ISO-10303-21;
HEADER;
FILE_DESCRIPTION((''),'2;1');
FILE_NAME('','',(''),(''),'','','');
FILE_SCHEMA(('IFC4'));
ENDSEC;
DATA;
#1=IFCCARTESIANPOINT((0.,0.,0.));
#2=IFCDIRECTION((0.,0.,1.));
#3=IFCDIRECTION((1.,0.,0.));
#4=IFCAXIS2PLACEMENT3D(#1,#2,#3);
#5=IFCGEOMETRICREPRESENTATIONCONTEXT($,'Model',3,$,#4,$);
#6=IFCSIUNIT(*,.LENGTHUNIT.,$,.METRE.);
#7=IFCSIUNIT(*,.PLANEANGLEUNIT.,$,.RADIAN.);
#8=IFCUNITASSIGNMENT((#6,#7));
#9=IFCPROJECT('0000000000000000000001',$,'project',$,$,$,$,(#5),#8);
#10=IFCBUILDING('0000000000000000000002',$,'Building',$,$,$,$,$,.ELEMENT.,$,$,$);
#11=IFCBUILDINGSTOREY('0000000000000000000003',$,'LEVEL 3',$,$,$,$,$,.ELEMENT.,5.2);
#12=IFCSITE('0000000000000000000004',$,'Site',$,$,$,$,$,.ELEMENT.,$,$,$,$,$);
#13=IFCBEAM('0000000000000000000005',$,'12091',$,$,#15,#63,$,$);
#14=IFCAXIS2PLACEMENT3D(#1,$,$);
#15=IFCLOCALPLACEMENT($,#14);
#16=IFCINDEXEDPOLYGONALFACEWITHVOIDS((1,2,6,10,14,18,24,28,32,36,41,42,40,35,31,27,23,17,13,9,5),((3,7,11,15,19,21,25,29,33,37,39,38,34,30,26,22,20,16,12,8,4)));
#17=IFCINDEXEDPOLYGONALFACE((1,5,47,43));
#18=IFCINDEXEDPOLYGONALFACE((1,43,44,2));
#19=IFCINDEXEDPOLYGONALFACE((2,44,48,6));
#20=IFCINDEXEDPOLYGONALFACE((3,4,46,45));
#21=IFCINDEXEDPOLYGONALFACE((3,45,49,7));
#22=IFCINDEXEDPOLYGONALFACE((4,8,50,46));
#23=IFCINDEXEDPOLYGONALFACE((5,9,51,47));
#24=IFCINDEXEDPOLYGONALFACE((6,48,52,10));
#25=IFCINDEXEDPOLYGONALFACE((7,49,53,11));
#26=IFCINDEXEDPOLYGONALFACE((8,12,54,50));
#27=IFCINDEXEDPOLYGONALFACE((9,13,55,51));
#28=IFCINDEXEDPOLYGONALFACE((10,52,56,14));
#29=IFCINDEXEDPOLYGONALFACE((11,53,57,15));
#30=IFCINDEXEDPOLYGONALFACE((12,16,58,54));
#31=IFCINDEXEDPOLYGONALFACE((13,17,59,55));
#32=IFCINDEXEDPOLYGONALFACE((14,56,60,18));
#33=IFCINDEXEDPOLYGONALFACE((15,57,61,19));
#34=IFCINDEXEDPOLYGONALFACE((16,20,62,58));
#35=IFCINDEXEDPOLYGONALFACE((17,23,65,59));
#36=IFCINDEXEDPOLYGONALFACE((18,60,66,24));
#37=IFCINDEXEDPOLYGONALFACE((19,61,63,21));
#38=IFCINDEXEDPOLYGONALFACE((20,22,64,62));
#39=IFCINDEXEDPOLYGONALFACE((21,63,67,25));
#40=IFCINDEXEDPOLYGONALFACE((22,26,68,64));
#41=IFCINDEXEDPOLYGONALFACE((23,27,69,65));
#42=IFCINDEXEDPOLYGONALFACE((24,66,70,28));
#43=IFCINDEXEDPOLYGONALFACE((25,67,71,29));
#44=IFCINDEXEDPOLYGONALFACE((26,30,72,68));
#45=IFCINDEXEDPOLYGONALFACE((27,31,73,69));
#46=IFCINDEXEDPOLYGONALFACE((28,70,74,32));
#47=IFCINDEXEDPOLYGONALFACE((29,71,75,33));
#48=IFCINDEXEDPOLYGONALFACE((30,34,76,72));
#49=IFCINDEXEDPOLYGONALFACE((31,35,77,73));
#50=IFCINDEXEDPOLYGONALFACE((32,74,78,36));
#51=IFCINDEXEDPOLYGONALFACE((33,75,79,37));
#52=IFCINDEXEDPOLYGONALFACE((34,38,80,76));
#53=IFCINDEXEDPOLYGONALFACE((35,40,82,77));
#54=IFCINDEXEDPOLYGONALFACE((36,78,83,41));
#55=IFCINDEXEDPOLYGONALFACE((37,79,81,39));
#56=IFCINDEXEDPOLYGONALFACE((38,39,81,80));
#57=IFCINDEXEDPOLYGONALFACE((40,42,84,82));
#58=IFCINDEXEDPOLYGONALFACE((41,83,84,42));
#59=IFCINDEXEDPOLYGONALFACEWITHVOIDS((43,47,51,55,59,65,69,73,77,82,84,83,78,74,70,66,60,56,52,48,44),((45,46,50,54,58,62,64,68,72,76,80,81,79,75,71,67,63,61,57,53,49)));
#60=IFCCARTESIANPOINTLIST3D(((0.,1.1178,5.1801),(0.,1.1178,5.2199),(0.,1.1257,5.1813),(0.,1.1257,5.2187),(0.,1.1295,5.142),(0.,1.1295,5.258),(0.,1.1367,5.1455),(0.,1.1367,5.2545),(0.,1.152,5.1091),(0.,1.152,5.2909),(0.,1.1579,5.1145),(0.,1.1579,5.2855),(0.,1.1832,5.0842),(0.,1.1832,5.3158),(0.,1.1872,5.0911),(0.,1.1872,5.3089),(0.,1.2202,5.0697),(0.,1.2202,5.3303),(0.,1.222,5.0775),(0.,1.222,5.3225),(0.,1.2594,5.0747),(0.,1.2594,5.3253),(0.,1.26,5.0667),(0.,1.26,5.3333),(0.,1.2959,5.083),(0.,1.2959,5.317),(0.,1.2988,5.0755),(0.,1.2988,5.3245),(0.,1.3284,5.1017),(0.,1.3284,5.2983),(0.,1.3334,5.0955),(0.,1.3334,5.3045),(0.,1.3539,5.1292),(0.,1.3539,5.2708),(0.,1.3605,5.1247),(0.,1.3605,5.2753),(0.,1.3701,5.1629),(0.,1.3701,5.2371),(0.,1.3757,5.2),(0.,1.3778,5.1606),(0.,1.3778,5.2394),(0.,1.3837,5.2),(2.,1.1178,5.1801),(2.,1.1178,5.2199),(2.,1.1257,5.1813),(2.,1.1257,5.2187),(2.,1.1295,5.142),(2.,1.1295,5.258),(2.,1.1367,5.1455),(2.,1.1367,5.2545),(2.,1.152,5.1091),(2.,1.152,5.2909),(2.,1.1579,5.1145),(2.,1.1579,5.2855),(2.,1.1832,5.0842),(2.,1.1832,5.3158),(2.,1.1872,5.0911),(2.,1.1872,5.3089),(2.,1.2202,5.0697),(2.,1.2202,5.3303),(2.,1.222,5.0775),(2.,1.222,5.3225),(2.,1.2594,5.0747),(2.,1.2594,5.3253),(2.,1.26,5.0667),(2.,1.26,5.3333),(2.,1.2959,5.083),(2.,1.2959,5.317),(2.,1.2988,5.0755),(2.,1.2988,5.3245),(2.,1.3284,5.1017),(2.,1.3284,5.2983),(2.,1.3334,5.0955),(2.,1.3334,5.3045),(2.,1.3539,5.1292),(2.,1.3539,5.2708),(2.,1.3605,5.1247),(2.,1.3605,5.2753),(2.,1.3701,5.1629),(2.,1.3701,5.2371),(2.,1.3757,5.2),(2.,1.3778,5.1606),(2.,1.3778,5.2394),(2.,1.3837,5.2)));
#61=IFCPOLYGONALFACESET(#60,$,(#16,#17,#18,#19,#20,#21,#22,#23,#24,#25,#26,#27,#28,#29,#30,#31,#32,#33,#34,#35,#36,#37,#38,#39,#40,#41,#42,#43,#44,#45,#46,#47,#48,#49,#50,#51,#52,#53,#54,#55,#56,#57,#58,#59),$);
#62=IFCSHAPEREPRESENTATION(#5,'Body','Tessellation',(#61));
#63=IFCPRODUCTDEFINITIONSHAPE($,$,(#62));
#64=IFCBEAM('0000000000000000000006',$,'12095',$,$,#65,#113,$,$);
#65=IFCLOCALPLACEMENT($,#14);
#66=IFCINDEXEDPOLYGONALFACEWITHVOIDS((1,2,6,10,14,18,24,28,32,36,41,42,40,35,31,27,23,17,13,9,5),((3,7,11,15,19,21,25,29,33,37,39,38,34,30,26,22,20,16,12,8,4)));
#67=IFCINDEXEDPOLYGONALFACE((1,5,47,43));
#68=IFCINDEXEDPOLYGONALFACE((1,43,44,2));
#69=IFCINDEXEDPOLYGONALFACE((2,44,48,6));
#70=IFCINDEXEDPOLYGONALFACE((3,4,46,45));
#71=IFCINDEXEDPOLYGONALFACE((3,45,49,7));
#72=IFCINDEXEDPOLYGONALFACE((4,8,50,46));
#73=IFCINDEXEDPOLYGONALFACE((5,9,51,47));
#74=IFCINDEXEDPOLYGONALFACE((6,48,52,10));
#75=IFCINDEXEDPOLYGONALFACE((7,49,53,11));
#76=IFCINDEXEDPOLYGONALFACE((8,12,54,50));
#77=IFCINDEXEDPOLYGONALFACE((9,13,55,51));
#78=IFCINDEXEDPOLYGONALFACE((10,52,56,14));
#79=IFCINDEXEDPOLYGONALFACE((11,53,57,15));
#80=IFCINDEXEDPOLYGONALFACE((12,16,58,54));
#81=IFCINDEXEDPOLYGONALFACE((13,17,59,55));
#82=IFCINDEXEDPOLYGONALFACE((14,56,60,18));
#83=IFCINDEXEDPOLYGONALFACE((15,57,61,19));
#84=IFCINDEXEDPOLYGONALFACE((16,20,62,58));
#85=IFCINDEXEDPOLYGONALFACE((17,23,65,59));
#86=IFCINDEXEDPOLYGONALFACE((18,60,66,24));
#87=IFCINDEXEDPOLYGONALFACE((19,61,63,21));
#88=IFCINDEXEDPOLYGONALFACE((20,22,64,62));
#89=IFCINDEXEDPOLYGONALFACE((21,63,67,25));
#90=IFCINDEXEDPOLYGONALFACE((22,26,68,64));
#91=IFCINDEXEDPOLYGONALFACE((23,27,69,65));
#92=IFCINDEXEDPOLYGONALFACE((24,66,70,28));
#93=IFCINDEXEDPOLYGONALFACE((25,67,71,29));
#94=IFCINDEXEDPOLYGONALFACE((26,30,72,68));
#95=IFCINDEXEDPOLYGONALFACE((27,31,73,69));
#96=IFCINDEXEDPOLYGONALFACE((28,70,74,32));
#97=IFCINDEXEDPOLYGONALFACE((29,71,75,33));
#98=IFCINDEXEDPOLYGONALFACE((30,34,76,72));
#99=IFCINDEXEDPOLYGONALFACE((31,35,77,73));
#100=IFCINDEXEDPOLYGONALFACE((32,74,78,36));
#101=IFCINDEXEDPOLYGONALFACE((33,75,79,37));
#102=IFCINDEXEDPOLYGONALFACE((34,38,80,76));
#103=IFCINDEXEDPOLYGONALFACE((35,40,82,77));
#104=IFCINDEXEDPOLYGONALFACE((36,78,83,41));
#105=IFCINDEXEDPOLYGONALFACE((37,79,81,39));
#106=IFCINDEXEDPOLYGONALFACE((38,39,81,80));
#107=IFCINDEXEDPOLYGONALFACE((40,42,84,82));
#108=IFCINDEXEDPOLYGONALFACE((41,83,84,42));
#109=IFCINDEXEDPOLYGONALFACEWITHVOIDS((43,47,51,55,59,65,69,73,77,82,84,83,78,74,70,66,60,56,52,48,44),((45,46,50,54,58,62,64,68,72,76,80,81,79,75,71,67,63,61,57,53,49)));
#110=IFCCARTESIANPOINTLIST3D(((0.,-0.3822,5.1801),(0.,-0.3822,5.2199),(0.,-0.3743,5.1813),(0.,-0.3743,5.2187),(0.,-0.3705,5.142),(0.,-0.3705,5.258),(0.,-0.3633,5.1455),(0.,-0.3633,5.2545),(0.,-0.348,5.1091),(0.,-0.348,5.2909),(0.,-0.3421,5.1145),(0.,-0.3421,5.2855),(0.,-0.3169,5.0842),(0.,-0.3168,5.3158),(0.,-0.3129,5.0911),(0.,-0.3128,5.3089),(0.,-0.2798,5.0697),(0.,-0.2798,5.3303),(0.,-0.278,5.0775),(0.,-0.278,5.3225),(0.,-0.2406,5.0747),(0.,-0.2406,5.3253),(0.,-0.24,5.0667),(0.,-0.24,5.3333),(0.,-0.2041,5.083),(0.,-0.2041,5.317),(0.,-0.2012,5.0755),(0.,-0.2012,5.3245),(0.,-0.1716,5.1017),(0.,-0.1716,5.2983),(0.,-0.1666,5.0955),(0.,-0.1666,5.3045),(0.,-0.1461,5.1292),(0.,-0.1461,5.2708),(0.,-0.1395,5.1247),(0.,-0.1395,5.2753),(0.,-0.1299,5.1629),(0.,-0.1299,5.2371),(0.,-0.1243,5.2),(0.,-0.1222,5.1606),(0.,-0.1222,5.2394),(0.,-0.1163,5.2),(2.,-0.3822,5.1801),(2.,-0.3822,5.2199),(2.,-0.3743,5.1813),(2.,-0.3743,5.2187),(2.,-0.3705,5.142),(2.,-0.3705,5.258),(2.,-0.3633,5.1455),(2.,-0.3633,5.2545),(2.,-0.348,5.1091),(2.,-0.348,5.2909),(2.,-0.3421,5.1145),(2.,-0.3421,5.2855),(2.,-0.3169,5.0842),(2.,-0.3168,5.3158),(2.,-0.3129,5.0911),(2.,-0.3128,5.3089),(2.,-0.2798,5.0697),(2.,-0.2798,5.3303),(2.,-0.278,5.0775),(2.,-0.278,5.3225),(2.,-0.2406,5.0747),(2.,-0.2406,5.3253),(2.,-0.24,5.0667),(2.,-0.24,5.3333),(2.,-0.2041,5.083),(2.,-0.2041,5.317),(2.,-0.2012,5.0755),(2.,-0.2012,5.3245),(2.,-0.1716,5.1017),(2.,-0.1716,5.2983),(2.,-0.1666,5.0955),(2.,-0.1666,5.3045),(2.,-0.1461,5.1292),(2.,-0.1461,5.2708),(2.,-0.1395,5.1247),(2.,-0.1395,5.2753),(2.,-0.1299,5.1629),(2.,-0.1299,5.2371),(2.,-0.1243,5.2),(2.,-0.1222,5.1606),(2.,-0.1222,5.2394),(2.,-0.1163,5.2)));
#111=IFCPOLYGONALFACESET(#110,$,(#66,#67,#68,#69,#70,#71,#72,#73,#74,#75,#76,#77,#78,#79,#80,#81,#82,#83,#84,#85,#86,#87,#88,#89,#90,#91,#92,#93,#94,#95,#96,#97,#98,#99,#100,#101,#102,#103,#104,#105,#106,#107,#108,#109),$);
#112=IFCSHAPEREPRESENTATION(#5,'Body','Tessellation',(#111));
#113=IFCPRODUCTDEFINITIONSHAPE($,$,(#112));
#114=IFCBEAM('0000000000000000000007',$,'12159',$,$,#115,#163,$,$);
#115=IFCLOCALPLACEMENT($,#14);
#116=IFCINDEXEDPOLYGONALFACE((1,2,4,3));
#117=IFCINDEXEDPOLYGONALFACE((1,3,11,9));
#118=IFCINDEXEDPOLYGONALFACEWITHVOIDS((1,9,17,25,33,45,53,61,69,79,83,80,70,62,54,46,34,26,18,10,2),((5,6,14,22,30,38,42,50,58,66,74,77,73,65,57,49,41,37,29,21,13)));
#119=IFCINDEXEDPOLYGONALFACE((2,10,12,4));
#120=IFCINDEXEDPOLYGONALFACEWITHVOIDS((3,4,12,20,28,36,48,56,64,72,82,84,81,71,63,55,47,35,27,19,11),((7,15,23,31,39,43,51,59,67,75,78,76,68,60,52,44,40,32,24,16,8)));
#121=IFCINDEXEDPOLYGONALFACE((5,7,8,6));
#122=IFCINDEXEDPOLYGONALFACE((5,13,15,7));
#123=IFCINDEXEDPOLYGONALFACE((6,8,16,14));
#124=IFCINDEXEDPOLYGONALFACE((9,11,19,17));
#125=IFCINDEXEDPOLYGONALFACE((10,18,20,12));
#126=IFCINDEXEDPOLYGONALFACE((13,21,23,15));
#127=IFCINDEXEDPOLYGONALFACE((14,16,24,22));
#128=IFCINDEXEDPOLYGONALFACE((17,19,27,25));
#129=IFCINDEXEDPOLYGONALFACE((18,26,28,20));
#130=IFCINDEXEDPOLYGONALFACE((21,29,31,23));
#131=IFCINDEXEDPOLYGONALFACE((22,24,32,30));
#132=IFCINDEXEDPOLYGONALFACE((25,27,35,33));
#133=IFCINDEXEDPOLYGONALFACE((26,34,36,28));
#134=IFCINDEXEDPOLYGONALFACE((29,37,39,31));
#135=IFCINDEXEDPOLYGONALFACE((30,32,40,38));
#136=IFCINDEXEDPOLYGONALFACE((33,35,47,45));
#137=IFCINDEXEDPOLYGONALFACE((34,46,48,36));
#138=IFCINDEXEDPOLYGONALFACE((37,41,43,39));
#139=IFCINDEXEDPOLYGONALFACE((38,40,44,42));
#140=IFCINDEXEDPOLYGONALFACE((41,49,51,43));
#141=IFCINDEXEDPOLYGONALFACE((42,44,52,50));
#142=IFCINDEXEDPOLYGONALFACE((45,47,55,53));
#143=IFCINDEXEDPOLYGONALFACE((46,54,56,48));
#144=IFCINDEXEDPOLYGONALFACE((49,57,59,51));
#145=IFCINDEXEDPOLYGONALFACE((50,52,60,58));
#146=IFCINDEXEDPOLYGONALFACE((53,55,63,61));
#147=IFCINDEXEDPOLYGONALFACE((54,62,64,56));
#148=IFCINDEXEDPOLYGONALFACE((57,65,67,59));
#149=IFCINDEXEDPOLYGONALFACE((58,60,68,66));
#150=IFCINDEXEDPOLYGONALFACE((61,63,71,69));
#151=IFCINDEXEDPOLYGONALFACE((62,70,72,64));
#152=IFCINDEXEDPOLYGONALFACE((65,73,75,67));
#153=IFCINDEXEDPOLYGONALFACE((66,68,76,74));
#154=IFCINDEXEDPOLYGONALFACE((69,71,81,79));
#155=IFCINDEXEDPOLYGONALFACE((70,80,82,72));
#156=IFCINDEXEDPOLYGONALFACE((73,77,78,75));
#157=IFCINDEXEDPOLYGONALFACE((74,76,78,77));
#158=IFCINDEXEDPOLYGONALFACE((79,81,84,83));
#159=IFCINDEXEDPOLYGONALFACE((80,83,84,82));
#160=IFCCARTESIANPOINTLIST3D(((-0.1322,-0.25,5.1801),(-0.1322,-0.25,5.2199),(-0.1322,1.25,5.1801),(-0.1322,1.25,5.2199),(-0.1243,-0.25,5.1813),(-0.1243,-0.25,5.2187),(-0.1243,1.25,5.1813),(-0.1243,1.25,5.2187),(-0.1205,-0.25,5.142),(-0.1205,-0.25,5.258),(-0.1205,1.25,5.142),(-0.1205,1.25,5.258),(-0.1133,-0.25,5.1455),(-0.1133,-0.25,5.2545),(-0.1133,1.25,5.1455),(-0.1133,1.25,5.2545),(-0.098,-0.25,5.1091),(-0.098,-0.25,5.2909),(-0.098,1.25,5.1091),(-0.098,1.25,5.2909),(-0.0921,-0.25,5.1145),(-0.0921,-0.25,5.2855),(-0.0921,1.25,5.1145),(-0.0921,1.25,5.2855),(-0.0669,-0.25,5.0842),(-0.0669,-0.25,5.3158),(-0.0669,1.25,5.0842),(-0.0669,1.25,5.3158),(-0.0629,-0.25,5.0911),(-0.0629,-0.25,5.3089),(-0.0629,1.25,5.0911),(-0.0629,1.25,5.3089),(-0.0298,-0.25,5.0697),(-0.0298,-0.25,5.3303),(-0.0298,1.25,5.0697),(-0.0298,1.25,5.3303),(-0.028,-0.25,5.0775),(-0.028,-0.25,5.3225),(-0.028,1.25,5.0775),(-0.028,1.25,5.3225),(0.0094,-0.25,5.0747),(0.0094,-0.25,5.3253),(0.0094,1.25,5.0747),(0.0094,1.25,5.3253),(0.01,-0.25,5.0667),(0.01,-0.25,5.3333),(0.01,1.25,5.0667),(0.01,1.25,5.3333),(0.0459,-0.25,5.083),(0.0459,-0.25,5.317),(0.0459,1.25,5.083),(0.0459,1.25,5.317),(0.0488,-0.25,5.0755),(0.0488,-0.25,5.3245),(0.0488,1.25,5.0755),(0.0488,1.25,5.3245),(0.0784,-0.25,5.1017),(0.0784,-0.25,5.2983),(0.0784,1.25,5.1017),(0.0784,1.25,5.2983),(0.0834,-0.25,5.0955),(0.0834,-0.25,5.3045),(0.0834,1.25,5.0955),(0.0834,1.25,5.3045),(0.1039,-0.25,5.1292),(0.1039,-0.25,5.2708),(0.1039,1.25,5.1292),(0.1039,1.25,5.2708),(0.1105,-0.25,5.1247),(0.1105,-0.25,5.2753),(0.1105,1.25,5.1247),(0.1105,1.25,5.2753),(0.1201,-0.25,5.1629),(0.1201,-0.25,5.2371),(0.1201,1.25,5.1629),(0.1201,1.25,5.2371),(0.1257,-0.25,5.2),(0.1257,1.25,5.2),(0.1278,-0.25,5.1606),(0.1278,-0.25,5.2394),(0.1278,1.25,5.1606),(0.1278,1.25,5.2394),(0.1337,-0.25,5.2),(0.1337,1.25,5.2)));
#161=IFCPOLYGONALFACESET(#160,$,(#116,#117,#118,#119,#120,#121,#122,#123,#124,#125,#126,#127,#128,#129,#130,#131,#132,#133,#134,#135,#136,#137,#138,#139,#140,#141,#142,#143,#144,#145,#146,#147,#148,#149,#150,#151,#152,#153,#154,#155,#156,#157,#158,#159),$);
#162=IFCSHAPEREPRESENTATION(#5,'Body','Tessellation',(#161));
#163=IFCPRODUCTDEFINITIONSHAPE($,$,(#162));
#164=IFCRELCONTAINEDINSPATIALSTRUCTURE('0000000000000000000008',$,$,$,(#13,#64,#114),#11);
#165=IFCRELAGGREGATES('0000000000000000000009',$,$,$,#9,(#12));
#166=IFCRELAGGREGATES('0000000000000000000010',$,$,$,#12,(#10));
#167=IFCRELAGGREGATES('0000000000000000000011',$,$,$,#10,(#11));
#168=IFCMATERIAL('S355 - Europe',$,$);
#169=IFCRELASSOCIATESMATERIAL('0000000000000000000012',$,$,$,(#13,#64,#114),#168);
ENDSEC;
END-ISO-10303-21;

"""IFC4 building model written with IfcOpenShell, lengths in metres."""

from ifc_helpers import new_model, si_unit, frame, origin_with_axes, origin_2d_with_axis, place, context, project, spatial, hollow_circle, extrude, material, material_profile, profile_set, profile_usage, element, save


model = new_model("IFC4")

# Units and contexts
model_context = context("Model", 3, world=origin_with_axes())
ifc_project = project(units=[si_unit("LENGTHUNIT", "METRE"), si_unit("PLANEANGLEUNIT", "RADIAN")], contexts=[model_context])

# Site, building, storey
site = spatial("IfcSite", under=ifc_project, Name="Site", CompositionType="ELEMENT")
building = spatial("IfcBuilding", under=site, Name="Building", CompositionType="ELEMENT")
storey = spatial("IfcBuildingStorey", under=building, Name="LEVEL 3", CompositionType="ELEMENT", Elevation=5.2)

# Shared definitions
ifc_material = material(Name="S355 - Europe")

# Beams
ifc_material_profile_1 = material_profile(ifc_material, hollow_circle(Radius=0.1337, WallThickness=0.008, at=origin_2d_with_axis()))
ifc_profile_set_1 = profile_set([ifc_material_profile_1])
ifc_profile_usage_1 = profile_usage(ifc_profile_set_1, cardinal=10)
beam_1_placement = place(None, frame((0.0, 1.25, 5.2), z_axis=(1.0, 0.0, 0.0), x_axis=(0.0, 1.0, 0.0)))
element("IfcBeam", 1, at=beam_1_placement, inside=storey, material=ifc_profile_usage_1, Name="12091", context=model_context, shape_type="SweptSolid", body=[
    extrude(hollow_circle(Radius=0.1337, WallThickness=0.008, at=origin_2d_with_axis()), origin_with_axes(), (0.0, 0.0, 1.0), 2.0),
])
ifc_material_profile_2 = material_profile(ifc_material, hollow_circle(Radius=0.1337, WallThickness=0.008, at=origin_2d_with_axis()))
ifc_profile_set_2 = profile_set([ifc_material_profile_2])
ifc_profile_usage_2 = profile_usage(ifc_profile_set_2, cardinal=10)
beam_2_placement = place(None, frame((0.0, -0.25, 5.2), z_axis=(1.0, 0.0, 0.0), x_axis=(0.0, 1.0, 0.0)))
element("IfcBeam", 2, at=beam_2_placement, inside=storey, material=ifc_profile_usage_2, Name="12095", context=model_context, shape_type="SweptSolid", body=[
    extrude(hollow_circle(Radius=0.1337, WallThickness=0.008, at=origin_2d_with_axis()), origin_with_axes(), (0.0, 0.0, 1.0), 2.0),
])
ifc_material_profile_3 = material_profile(ifc_material, hollow_circle(Radius=0.1337, WallThickness=0.008, at=origin_2d_with_axis()))
ifc_profile_set_3 = profile_set([ifc_material_profile_3])
ifc_profile_usage_3 = profile_usage(ifc_profile_set_3, cardinal=10)
beam_3_placement = place(None, frame((0.0, 1.25, 5.2), z_axis=(0.0, -1.0, 0.0), x_axis=(1.0, 0.0, 0.0)))
element("IfcBeam", 3, at=beam_3_placement, inside=storey, material=ifc_profile_usage_3, Name="12159", context=model_context, shape_type="SweptSolid", body=[
    extrude(hollow_circle(Radius=0.1337, WallThickness=0.008, at=origin_2d_with_axis()), origin_with_axes(), (0.0, 0.0, 1.0), 1.5),
])

save(model, "model.ifc")
